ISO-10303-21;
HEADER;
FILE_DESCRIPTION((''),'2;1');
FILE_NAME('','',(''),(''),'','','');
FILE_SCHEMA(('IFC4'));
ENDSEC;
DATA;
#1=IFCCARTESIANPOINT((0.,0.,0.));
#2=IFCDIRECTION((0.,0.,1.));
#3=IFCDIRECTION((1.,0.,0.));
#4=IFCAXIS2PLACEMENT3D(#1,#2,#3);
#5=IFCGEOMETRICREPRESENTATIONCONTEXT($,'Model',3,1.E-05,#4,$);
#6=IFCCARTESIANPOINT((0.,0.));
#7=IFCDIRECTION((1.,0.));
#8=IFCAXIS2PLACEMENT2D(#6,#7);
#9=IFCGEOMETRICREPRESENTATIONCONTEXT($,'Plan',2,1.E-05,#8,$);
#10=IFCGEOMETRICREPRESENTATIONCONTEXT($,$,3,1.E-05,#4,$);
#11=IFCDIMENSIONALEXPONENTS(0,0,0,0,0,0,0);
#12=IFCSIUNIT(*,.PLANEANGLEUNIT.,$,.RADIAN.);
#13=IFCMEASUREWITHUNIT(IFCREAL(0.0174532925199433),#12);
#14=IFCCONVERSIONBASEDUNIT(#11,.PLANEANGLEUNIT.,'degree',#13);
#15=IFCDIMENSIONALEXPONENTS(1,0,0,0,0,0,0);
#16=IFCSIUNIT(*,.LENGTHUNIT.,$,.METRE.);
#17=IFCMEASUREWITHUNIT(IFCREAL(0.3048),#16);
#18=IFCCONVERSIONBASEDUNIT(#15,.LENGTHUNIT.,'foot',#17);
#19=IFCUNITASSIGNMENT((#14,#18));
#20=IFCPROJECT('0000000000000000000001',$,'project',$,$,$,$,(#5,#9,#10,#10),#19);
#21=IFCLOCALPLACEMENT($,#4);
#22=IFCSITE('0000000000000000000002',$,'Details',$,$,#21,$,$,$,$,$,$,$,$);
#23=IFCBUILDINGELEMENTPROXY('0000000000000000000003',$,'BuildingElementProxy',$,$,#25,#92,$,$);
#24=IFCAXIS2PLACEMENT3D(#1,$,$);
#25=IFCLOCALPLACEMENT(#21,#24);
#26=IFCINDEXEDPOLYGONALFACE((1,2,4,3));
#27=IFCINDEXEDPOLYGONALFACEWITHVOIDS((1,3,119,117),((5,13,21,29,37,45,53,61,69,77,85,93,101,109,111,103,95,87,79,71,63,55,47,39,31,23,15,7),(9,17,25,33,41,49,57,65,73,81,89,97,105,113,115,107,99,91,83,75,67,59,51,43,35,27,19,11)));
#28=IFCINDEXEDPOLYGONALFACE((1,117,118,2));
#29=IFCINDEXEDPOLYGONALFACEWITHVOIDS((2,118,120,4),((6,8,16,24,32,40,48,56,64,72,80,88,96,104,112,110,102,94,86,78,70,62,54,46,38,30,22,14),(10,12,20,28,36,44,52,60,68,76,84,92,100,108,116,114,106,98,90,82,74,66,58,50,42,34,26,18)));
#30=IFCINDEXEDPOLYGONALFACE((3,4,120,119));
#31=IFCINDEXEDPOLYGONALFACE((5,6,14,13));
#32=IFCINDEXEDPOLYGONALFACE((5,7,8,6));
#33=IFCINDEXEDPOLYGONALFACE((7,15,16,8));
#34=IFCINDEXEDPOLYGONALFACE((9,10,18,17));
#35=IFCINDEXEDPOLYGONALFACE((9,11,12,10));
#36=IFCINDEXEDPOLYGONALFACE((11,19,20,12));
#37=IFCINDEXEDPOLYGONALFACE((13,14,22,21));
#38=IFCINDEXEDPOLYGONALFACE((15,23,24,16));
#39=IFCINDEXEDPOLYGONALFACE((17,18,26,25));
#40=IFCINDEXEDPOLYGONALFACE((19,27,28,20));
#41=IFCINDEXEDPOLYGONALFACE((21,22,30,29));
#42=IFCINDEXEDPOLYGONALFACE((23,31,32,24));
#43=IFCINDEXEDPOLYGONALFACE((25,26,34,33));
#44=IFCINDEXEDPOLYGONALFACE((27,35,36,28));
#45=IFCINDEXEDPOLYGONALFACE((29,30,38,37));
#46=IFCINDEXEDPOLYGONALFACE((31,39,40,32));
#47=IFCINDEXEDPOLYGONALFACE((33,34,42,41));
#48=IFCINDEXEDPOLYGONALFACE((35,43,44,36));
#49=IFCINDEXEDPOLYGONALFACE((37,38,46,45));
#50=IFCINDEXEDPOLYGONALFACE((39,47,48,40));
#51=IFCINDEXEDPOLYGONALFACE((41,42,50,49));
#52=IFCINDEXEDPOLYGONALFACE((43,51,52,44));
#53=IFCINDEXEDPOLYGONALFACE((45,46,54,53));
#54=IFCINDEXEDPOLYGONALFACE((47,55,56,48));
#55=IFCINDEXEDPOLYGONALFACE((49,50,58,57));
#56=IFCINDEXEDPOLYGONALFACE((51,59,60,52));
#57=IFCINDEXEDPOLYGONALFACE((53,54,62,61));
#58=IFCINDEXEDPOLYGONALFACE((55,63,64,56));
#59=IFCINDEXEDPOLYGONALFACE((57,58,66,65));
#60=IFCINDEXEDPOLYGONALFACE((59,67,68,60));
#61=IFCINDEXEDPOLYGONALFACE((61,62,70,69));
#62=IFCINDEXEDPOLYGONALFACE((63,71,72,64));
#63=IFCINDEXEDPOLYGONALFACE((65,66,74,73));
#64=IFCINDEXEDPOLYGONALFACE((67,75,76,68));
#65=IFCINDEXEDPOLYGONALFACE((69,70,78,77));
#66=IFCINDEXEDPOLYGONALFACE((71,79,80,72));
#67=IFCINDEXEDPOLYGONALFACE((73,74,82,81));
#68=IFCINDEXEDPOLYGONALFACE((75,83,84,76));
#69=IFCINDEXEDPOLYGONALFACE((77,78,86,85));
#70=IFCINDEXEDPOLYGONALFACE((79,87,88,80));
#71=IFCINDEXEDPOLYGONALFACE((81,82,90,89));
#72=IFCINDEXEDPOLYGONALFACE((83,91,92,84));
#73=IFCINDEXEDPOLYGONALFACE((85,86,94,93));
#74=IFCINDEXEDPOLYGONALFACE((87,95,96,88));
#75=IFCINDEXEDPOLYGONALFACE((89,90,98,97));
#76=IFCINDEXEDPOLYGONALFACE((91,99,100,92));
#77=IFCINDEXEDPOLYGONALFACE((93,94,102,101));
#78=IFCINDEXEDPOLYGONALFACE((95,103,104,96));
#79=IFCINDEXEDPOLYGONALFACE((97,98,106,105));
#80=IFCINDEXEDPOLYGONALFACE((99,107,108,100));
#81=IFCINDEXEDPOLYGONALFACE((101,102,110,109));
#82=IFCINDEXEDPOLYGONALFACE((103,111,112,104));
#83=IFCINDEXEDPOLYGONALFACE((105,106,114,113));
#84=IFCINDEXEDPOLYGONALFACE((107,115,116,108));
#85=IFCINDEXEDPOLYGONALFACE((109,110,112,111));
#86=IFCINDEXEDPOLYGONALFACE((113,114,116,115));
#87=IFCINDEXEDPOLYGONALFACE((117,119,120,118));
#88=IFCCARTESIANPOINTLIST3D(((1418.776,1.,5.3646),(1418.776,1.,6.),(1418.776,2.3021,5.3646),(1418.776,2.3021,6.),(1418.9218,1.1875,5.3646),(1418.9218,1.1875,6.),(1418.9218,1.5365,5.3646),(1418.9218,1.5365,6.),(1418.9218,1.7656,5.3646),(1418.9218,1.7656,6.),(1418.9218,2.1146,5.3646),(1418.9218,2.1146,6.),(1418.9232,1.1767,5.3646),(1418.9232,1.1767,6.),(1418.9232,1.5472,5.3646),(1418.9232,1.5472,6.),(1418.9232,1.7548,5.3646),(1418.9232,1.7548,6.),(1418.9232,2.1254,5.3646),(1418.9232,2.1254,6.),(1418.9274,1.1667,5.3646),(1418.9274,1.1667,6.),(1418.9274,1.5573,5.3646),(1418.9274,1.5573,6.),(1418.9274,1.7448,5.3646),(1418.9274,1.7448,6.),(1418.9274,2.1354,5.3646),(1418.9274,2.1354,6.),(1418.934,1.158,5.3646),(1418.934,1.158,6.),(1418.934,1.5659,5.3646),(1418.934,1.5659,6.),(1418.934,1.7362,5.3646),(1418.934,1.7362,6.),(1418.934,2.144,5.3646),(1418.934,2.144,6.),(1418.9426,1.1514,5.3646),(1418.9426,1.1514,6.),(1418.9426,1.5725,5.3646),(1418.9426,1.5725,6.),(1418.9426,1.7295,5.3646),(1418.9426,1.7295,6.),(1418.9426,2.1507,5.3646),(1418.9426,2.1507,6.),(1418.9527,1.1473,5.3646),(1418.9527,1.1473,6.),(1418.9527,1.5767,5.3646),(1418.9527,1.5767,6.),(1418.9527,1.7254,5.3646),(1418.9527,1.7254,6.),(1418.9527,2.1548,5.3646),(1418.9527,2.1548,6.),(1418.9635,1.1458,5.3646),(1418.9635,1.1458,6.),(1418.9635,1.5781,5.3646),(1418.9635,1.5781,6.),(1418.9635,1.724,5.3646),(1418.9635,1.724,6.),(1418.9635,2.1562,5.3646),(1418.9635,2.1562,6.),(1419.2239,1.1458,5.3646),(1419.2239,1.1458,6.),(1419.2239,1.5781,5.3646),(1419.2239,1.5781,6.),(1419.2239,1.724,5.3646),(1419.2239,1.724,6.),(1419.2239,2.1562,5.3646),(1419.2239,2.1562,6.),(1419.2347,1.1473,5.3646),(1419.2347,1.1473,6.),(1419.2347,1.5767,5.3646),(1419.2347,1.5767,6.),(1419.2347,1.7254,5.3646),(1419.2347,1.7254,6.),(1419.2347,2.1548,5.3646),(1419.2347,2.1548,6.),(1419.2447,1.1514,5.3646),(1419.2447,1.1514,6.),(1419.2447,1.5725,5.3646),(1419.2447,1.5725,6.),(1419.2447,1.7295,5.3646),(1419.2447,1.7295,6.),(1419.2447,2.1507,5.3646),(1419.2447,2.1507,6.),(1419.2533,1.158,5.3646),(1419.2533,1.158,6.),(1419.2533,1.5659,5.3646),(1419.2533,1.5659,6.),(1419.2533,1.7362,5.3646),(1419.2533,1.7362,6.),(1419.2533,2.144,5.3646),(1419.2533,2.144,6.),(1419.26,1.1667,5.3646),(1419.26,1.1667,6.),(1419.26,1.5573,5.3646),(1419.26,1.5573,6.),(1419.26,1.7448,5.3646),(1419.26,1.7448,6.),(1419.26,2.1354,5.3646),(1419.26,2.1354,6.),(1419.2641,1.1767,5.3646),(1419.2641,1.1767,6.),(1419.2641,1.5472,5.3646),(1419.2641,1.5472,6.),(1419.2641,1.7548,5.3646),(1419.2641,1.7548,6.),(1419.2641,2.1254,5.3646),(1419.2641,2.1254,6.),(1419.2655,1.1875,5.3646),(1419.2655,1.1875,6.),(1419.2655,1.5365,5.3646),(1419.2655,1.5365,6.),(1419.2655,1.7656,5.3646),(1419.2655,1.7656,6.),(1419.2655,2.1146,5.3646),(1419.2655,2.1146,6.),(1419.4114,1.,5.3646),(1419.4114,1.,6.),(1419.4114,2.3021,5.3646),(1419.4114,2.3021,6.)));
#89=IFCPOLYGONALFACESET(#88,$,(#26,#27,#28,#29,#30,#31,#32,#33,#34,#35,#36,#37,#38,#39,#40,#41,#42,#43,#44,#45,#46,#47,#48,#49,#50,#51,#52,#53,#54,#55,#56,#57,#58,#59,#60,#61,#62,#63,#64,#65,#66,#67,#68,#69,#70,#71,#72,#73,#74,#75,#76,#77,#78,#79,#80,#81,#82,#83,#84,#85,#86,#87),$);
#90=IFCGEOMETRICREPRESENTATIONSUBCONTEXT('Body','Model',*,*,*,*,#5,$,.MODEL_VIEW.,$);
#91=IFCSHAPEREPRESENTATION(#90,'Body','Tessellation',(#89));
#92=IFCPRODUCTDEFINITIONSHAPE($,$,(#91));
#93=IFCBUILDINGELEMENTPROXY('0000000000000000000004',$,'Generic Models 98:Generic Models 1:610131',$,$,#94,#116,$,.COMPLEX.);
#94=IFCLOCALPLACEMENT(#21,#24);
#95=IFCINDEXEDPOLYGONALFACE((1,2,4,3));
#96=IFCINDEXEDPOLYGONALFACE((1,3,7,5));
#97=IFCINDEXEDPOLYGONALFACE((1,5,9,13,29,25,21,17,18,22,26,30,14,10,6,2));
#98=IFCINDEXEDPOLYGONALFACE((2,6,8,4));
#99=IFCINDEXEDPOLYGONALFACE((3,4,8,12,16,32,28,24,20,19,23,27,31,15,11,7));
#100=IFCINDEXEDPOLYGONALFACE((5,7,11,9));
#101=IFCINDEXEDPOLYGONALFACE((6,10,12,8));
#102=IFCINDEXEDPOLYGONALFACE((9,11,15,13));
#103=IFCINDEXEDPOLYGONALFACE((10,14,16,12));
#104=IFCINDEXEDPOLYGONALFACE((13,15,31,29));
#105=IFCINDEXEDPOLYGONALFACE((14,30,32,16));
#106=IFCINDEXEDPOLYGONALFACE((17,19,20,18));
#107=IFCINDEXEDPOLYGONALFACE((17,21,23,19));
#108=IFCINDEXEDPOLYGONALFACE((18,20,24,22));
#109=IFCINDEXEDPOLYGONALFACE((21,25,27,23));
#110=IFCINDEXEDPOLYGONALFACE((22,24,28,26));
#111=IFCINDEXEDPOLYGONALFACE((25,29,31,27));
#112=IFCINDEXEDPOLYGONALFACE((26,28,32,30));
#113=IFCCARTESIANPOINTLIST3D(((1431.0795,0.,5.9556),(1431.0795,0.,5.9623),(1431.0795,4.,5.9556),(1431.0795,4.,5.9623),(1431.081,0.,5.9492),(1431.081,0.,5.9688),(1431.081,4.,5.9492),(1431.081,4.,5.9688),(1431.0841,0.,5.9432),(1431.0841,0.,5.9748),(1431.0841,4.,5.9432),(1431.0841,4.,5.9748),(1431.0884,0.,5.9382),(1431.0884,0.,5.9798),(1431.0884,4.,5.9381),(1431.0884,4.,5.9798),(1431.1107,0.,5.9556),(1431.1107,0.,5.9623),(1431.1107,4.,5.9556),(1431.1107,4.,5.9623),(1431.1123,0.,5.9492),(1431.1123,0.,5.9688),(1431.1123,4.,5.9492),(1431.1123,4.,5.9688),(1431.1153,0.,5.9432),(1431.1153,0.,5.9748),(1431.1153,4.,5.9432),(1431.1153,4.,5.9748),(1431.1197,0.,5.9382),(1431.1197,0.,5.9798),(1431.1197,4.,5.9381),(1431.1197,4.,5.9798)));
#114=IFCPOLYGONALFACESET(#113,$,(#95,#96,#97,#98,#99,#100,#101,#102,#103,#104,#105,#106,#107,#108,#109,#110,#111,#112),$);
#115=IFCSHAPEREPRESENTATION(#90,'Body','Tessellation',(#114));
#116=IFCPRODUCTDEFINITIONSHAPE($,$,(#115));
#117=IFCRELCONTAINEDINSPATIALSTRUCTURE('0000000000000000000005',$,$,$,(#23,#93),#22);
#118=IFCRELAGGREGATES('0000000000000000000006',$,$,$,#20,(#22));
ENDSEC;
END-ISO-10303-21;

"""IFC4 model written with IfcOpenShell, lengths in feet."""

from ifc_helpers import new_model, entity, si_unit, converted_unit, frame, origin_with_axes, origin_2d_with_axis, place, context, subcontext, project, spatial, line, indexed_curve, outline, extrude, element, save


model = new_model("IFC4")

# Units and contexts
model_context = context("Model", 3, precision=1e-05, world=origin_with_axes())
plan_context = context("Plan", 2, precision=1e-05, world=origin_2d_with_axis())
context_of_model = context(None, 3, precision=1e-05, world=origin_with_axes())
body_context = subcontext(model_context, "Body", "Model", "MODEL_VIEW")
ifc_project = project(units=[converted_unit("PLANEANGLEUNIT", "degree", entity("IfcReal", 0.0174532925199433), si_unit("PLANEANGLEUNIT", "RADIAN"), dimensions=[0, 0, 0, 0, 0, 0, 0]), converted_unit("LENGTHUNIT", "foot", entity("IfcReal", 0.3048), si_unit("LENGTHUNIT", "METRE"), dimensions=[1, 0, 0, 0, 0, 0, 0])], contexts=[model_context, plan_context, context_of_model, context_of_model])

# Site
site_placement = place(None, origin_with_axes())
site = spatial("IfcSite", under=ifc_project, at=site_placement, Name="Details")

# Building element proxies
proxy_1_placement = place(site_placement, frame((1419.0936, 2.3021, 5.3646), z_axis=(0.0, 0.0, 1.0), x_axis=(0.0, 1.0, 0.0)))
element("IfcBuildingElementProxy", 1, at=proxy_1_placement, inside=site, Name="BuildingElementProxy", context=body_context, shape_type="SweptSolid", body=[
    extrude(outline(indexed_curve([(-0.3177, -0.651), (0.3177, -0.651), (0.3177, 0.651), (-0.3177, 0.651), (0.1719, -0.1146), (0.1719, -0.4635), (0.1705, -0.4743), (0.1663, -0.4844), (0.1597, -0.493), (0.151, -0.4996), (0.141, -0.5038), (0.1302, -0.5052), (-0.1302, -0.5052), (-0.141, -0.5038), (-0.151, -0.4996), (-0.1597, -0.493), (-0.1663, -0.4844), (-0.1705, -0.4743), (-0.1719, -0.4635), (-0.1719, -0.1146), (-0.1705, -0.1038), (-0.1663, -0.0938), (-0.1597, -0.0851), (-0.151, -0.0785), (-0.141, -0.0743), (-0.1302, -0.0729), (0.1302, -0.0729), (0.141, -0.0743), (0.151, -0.0785), (0.1597, -0.0851), (0.1663, -0.0938), (0.1705, -0.1038), (0.151, 0.0785), (0.141, 0.0743), (0.1302, 0.0729), (-0.1302, 0.0729), (-0.141, 0.0743), (-0.151, 0.0785), (-0.1597, 0.0851), (-0.1663, 0.0937), (-0.1705, 0.1038), (-0.1719, 0.1146), (-0.1719, 0.4635), (-0.1705, 0.4743), (-0.1663, 0.4844), (-0.1597, 0.493), (-0.151, 0.4996), (-0.141, 0.5038), (-0.1302, 0.5052), (0.1302, 0.5052), (0.141, 0.5038), (0.151, 0.4996), (0.1597, 0.493), (0.1663, 0.4844), (0.1705, 0.4743), (0.1719, 0.4635), (0.1719, 0.1146), (0.1705, 0.1038), (0.1663, 0.0937), (0.1597, 0.0851)], segments=[line(4, 3), line(3, 2), line(2, 1), line(1, 4)], self_intersect=False), holes=[indexed_curve([(-0.3177, -0.651), (0.3177, -0.651), (0.3177, 0.651), (-0.3177, 0.651), (0.1719, -0.1146), (0.1719, -0.4635), (0.1705, -0.4743), (0.1663, -0.4844), (0.1597, -0.493), (0.151, -0.4996), (0.141, -0.5038), (0.1302, -0.5052), (-0.1302, -0.5052), (-0.141, -0.5038), (-0.151, -0.4996), (-0.1597, -0.493), (-0.1663, -0.4844), (-0.1705, -0.4743), (-0.1719, -0.4635), (-0.1719, -0.1146), (-0.1705, -0.1038), (-0.1663, -0.0938), (-0.1597, -0.0851), (-0.151, -0.0785), (-0.141, -0.0743), (-0.1302, -0.0729), (0.1302, -0.0729), (0.141, -0.0743), (0.151, -0.0785), (0.1597, -0.0851), (0.1663, -0.0938), (0.1705, -0.1038), (0.151, 0.0785), (0.141, 0.0743), (0.1302, 0.0729), (-0.1302, 0.0729), (-0.141, 0.0743), (-0.151, 0.0785), (-0.1597, 0.0851), (-0.1663, 0.0937), (-0.1705, 0.1038), (-0.1719, 0.1146), (-0.1719, 0.4635), (-0.1705, 0.4743), (-0.1663, 0.4844), (-0.1597, 0.493), (-0.151, 0.4996), (-0.141, 0.5038), (-0.1302, 0.5052), (0.1302, 0.5052), (0.141, 0.5038), (0.151, 0.4996), (0.1597, 0.493), (0.1663, 0.4844), (0.1705, 0.4743), (0.1719, 0.4635), (0.1719, 0.1146), (0.1705, 0.1038), (0.1663, 0.0937), (0.1597, 0.0851)], segments=[line(20, 19), line(19, 18), line(18, 17), line(17, 16), line(16, 15), line(15, 14), line(14, 13), line(13, 12), line(12, 11), line(11, 10), line(10, 9), line(9, 8), line(8, 7), line(7, 6), line(6, 5), line(5, 32), line(32, 31), line(31, 30), line(30, 29), line(29, 28), line(28, 27), line(27, 26), line(26, 25), line(25, 24), line(24, 23), line(23, 22), line(22, 21), line(21, 20)], self_intersect=False), indexed_curve([(-0.3177, -0.651), (0.3177, -0.651), (0.3177, 0.651), (-0.3177, 0.651), (0.1719, -0.1146), (0.1719, -0.4635), (0.1705, -0.4743), (0.1663, -0.4844), (0.1597, -0.493), (0.151, -0.4996), (0.141, -0.5038), (0.1302, -0.5052), (-0.1302, -0.5052), (-0.141, -0.5038), (-0.151, -0.4996), (-0.1597, -0.493), (-0.1663, -0.4844), (-0.1705, -0.4743), (-0.1719, -0.4635), (-0.1719, -0.1146), (-0.1705, -0.1038), (-0.1663, -0.0938), (-0.1597, -0.0851), (-0.151, -0.0785), (-0.141, -0.0743), (-0.1302, -0.0729), (0.1302, -0.0729), (0.141, -0.0743), (0.151, -0.0785), (0.1597, -0.0851), (0.1663, -0.0938), (0.1705, -0.1038), (0.151, 0.0785), (0.141, 0.0743), (0.1302, 0.0729), (-0.1302, 0.0729), (-0.141, 0.0743), (-0.151, 0.0785), (-0.1597, 0.0851), (-0.1663, 0.0937), (-0.1705, 0.1038), (-0.1719, 0.1146), (-0.1719, 0.4635), (-0.1705, 0.4743), (-0.1663, 0.4844), (-0.1597, 0.493), (-0.151, 0.4996), (-0.141, 0.5038), (-0.1302, 0.5052), (0.1302, 0.5052), (0.141, 0.5038), (0.151, 0.4996), (0.1597, 0.493), (0.1663, 0.4844), (0.1705, 0.4743), (0.1719, 0.4635), (0.1719, 0.1146), (0.1705, 0.1038), (0.1663, 0.0937), (0.1597, 0.0851)], segments=[line(44, 43), line(43, 42), line(42, 41), line(41, 40), line(40, 39), line(39, 38), line(38, 37), line(37, 36), line(36, 35), line(35, 34), line(34, 33), line(33, 60), line(60, 59), line(59, 58), line(58, 57), line(57, 56), line(56, 55), line(55, 54), line(54, 53), line(53, 52), line(52, 51), line(51, 50), line(50, 49), line(49, 48), line(48, 47), line(47, 46), line(46, 45), line(45, 44)], self_intersect=False)]), frame((-0.651, 0.0, 0.0), z_axis=(0.0, 0.0, 1.0), x_axis=(0.0, -1.0, 0.0)), (0.0, 0.0, 1.0), 0.6354),
])
proxy_2_placement = place(site_placement, frame((1431.0795, 3.847, 5.9798), z_axis=(0.0, 1.0, 0.0), x_axis=(0.0, 0.0, -1.0)))
element("IfcBuildingElementProxy", 2, at=proxy_2_placement, inside=site, Name="Generic Models 98:Generic Models 1:610131", PredefinedType="COMPLEX", context=body_context, shape_type="SweptSolid", body=[
    extrude(outline(indexed_curve([(0.0115, 0.0043), (0.0166, 0.0), (0.0226, -0.003), (0.0291, -0.0045), (0.0039, -0.023), (-0.0026, -0.0215), (-0.0086, -0.0185), (-0.0137, -0.0142), (-0.0176, -0.0088), (-0.0202, -0.0026), (-0.0213, 0.004), (-0.0207, 0.0106), (0.0045, 0.0291), (0.0039, 0.0224), (0.005, 0.0159), (0.0076, 0.0097)], segments=[line(9, 8), line(8, 7), line(7, 6), line(6, 5), line(5, 4), line(4, 3), line(3, 2), line(2, 1), line(1, 16), line(16, 15), line(15, 14), line(14, 13), line(13, 12), line(12, 11), line(11, 10), line(10, 9)], self_intersect=False)), frame((0.0208, -0.0194, 0.153), z_axis=(0.0, 0.0, -1.0), x_axis=(0.591192, -0.806531, 0.000001)), (-0.000001, 0.0, 1.0), 4.0),
])

save(model, "model.ifc")
